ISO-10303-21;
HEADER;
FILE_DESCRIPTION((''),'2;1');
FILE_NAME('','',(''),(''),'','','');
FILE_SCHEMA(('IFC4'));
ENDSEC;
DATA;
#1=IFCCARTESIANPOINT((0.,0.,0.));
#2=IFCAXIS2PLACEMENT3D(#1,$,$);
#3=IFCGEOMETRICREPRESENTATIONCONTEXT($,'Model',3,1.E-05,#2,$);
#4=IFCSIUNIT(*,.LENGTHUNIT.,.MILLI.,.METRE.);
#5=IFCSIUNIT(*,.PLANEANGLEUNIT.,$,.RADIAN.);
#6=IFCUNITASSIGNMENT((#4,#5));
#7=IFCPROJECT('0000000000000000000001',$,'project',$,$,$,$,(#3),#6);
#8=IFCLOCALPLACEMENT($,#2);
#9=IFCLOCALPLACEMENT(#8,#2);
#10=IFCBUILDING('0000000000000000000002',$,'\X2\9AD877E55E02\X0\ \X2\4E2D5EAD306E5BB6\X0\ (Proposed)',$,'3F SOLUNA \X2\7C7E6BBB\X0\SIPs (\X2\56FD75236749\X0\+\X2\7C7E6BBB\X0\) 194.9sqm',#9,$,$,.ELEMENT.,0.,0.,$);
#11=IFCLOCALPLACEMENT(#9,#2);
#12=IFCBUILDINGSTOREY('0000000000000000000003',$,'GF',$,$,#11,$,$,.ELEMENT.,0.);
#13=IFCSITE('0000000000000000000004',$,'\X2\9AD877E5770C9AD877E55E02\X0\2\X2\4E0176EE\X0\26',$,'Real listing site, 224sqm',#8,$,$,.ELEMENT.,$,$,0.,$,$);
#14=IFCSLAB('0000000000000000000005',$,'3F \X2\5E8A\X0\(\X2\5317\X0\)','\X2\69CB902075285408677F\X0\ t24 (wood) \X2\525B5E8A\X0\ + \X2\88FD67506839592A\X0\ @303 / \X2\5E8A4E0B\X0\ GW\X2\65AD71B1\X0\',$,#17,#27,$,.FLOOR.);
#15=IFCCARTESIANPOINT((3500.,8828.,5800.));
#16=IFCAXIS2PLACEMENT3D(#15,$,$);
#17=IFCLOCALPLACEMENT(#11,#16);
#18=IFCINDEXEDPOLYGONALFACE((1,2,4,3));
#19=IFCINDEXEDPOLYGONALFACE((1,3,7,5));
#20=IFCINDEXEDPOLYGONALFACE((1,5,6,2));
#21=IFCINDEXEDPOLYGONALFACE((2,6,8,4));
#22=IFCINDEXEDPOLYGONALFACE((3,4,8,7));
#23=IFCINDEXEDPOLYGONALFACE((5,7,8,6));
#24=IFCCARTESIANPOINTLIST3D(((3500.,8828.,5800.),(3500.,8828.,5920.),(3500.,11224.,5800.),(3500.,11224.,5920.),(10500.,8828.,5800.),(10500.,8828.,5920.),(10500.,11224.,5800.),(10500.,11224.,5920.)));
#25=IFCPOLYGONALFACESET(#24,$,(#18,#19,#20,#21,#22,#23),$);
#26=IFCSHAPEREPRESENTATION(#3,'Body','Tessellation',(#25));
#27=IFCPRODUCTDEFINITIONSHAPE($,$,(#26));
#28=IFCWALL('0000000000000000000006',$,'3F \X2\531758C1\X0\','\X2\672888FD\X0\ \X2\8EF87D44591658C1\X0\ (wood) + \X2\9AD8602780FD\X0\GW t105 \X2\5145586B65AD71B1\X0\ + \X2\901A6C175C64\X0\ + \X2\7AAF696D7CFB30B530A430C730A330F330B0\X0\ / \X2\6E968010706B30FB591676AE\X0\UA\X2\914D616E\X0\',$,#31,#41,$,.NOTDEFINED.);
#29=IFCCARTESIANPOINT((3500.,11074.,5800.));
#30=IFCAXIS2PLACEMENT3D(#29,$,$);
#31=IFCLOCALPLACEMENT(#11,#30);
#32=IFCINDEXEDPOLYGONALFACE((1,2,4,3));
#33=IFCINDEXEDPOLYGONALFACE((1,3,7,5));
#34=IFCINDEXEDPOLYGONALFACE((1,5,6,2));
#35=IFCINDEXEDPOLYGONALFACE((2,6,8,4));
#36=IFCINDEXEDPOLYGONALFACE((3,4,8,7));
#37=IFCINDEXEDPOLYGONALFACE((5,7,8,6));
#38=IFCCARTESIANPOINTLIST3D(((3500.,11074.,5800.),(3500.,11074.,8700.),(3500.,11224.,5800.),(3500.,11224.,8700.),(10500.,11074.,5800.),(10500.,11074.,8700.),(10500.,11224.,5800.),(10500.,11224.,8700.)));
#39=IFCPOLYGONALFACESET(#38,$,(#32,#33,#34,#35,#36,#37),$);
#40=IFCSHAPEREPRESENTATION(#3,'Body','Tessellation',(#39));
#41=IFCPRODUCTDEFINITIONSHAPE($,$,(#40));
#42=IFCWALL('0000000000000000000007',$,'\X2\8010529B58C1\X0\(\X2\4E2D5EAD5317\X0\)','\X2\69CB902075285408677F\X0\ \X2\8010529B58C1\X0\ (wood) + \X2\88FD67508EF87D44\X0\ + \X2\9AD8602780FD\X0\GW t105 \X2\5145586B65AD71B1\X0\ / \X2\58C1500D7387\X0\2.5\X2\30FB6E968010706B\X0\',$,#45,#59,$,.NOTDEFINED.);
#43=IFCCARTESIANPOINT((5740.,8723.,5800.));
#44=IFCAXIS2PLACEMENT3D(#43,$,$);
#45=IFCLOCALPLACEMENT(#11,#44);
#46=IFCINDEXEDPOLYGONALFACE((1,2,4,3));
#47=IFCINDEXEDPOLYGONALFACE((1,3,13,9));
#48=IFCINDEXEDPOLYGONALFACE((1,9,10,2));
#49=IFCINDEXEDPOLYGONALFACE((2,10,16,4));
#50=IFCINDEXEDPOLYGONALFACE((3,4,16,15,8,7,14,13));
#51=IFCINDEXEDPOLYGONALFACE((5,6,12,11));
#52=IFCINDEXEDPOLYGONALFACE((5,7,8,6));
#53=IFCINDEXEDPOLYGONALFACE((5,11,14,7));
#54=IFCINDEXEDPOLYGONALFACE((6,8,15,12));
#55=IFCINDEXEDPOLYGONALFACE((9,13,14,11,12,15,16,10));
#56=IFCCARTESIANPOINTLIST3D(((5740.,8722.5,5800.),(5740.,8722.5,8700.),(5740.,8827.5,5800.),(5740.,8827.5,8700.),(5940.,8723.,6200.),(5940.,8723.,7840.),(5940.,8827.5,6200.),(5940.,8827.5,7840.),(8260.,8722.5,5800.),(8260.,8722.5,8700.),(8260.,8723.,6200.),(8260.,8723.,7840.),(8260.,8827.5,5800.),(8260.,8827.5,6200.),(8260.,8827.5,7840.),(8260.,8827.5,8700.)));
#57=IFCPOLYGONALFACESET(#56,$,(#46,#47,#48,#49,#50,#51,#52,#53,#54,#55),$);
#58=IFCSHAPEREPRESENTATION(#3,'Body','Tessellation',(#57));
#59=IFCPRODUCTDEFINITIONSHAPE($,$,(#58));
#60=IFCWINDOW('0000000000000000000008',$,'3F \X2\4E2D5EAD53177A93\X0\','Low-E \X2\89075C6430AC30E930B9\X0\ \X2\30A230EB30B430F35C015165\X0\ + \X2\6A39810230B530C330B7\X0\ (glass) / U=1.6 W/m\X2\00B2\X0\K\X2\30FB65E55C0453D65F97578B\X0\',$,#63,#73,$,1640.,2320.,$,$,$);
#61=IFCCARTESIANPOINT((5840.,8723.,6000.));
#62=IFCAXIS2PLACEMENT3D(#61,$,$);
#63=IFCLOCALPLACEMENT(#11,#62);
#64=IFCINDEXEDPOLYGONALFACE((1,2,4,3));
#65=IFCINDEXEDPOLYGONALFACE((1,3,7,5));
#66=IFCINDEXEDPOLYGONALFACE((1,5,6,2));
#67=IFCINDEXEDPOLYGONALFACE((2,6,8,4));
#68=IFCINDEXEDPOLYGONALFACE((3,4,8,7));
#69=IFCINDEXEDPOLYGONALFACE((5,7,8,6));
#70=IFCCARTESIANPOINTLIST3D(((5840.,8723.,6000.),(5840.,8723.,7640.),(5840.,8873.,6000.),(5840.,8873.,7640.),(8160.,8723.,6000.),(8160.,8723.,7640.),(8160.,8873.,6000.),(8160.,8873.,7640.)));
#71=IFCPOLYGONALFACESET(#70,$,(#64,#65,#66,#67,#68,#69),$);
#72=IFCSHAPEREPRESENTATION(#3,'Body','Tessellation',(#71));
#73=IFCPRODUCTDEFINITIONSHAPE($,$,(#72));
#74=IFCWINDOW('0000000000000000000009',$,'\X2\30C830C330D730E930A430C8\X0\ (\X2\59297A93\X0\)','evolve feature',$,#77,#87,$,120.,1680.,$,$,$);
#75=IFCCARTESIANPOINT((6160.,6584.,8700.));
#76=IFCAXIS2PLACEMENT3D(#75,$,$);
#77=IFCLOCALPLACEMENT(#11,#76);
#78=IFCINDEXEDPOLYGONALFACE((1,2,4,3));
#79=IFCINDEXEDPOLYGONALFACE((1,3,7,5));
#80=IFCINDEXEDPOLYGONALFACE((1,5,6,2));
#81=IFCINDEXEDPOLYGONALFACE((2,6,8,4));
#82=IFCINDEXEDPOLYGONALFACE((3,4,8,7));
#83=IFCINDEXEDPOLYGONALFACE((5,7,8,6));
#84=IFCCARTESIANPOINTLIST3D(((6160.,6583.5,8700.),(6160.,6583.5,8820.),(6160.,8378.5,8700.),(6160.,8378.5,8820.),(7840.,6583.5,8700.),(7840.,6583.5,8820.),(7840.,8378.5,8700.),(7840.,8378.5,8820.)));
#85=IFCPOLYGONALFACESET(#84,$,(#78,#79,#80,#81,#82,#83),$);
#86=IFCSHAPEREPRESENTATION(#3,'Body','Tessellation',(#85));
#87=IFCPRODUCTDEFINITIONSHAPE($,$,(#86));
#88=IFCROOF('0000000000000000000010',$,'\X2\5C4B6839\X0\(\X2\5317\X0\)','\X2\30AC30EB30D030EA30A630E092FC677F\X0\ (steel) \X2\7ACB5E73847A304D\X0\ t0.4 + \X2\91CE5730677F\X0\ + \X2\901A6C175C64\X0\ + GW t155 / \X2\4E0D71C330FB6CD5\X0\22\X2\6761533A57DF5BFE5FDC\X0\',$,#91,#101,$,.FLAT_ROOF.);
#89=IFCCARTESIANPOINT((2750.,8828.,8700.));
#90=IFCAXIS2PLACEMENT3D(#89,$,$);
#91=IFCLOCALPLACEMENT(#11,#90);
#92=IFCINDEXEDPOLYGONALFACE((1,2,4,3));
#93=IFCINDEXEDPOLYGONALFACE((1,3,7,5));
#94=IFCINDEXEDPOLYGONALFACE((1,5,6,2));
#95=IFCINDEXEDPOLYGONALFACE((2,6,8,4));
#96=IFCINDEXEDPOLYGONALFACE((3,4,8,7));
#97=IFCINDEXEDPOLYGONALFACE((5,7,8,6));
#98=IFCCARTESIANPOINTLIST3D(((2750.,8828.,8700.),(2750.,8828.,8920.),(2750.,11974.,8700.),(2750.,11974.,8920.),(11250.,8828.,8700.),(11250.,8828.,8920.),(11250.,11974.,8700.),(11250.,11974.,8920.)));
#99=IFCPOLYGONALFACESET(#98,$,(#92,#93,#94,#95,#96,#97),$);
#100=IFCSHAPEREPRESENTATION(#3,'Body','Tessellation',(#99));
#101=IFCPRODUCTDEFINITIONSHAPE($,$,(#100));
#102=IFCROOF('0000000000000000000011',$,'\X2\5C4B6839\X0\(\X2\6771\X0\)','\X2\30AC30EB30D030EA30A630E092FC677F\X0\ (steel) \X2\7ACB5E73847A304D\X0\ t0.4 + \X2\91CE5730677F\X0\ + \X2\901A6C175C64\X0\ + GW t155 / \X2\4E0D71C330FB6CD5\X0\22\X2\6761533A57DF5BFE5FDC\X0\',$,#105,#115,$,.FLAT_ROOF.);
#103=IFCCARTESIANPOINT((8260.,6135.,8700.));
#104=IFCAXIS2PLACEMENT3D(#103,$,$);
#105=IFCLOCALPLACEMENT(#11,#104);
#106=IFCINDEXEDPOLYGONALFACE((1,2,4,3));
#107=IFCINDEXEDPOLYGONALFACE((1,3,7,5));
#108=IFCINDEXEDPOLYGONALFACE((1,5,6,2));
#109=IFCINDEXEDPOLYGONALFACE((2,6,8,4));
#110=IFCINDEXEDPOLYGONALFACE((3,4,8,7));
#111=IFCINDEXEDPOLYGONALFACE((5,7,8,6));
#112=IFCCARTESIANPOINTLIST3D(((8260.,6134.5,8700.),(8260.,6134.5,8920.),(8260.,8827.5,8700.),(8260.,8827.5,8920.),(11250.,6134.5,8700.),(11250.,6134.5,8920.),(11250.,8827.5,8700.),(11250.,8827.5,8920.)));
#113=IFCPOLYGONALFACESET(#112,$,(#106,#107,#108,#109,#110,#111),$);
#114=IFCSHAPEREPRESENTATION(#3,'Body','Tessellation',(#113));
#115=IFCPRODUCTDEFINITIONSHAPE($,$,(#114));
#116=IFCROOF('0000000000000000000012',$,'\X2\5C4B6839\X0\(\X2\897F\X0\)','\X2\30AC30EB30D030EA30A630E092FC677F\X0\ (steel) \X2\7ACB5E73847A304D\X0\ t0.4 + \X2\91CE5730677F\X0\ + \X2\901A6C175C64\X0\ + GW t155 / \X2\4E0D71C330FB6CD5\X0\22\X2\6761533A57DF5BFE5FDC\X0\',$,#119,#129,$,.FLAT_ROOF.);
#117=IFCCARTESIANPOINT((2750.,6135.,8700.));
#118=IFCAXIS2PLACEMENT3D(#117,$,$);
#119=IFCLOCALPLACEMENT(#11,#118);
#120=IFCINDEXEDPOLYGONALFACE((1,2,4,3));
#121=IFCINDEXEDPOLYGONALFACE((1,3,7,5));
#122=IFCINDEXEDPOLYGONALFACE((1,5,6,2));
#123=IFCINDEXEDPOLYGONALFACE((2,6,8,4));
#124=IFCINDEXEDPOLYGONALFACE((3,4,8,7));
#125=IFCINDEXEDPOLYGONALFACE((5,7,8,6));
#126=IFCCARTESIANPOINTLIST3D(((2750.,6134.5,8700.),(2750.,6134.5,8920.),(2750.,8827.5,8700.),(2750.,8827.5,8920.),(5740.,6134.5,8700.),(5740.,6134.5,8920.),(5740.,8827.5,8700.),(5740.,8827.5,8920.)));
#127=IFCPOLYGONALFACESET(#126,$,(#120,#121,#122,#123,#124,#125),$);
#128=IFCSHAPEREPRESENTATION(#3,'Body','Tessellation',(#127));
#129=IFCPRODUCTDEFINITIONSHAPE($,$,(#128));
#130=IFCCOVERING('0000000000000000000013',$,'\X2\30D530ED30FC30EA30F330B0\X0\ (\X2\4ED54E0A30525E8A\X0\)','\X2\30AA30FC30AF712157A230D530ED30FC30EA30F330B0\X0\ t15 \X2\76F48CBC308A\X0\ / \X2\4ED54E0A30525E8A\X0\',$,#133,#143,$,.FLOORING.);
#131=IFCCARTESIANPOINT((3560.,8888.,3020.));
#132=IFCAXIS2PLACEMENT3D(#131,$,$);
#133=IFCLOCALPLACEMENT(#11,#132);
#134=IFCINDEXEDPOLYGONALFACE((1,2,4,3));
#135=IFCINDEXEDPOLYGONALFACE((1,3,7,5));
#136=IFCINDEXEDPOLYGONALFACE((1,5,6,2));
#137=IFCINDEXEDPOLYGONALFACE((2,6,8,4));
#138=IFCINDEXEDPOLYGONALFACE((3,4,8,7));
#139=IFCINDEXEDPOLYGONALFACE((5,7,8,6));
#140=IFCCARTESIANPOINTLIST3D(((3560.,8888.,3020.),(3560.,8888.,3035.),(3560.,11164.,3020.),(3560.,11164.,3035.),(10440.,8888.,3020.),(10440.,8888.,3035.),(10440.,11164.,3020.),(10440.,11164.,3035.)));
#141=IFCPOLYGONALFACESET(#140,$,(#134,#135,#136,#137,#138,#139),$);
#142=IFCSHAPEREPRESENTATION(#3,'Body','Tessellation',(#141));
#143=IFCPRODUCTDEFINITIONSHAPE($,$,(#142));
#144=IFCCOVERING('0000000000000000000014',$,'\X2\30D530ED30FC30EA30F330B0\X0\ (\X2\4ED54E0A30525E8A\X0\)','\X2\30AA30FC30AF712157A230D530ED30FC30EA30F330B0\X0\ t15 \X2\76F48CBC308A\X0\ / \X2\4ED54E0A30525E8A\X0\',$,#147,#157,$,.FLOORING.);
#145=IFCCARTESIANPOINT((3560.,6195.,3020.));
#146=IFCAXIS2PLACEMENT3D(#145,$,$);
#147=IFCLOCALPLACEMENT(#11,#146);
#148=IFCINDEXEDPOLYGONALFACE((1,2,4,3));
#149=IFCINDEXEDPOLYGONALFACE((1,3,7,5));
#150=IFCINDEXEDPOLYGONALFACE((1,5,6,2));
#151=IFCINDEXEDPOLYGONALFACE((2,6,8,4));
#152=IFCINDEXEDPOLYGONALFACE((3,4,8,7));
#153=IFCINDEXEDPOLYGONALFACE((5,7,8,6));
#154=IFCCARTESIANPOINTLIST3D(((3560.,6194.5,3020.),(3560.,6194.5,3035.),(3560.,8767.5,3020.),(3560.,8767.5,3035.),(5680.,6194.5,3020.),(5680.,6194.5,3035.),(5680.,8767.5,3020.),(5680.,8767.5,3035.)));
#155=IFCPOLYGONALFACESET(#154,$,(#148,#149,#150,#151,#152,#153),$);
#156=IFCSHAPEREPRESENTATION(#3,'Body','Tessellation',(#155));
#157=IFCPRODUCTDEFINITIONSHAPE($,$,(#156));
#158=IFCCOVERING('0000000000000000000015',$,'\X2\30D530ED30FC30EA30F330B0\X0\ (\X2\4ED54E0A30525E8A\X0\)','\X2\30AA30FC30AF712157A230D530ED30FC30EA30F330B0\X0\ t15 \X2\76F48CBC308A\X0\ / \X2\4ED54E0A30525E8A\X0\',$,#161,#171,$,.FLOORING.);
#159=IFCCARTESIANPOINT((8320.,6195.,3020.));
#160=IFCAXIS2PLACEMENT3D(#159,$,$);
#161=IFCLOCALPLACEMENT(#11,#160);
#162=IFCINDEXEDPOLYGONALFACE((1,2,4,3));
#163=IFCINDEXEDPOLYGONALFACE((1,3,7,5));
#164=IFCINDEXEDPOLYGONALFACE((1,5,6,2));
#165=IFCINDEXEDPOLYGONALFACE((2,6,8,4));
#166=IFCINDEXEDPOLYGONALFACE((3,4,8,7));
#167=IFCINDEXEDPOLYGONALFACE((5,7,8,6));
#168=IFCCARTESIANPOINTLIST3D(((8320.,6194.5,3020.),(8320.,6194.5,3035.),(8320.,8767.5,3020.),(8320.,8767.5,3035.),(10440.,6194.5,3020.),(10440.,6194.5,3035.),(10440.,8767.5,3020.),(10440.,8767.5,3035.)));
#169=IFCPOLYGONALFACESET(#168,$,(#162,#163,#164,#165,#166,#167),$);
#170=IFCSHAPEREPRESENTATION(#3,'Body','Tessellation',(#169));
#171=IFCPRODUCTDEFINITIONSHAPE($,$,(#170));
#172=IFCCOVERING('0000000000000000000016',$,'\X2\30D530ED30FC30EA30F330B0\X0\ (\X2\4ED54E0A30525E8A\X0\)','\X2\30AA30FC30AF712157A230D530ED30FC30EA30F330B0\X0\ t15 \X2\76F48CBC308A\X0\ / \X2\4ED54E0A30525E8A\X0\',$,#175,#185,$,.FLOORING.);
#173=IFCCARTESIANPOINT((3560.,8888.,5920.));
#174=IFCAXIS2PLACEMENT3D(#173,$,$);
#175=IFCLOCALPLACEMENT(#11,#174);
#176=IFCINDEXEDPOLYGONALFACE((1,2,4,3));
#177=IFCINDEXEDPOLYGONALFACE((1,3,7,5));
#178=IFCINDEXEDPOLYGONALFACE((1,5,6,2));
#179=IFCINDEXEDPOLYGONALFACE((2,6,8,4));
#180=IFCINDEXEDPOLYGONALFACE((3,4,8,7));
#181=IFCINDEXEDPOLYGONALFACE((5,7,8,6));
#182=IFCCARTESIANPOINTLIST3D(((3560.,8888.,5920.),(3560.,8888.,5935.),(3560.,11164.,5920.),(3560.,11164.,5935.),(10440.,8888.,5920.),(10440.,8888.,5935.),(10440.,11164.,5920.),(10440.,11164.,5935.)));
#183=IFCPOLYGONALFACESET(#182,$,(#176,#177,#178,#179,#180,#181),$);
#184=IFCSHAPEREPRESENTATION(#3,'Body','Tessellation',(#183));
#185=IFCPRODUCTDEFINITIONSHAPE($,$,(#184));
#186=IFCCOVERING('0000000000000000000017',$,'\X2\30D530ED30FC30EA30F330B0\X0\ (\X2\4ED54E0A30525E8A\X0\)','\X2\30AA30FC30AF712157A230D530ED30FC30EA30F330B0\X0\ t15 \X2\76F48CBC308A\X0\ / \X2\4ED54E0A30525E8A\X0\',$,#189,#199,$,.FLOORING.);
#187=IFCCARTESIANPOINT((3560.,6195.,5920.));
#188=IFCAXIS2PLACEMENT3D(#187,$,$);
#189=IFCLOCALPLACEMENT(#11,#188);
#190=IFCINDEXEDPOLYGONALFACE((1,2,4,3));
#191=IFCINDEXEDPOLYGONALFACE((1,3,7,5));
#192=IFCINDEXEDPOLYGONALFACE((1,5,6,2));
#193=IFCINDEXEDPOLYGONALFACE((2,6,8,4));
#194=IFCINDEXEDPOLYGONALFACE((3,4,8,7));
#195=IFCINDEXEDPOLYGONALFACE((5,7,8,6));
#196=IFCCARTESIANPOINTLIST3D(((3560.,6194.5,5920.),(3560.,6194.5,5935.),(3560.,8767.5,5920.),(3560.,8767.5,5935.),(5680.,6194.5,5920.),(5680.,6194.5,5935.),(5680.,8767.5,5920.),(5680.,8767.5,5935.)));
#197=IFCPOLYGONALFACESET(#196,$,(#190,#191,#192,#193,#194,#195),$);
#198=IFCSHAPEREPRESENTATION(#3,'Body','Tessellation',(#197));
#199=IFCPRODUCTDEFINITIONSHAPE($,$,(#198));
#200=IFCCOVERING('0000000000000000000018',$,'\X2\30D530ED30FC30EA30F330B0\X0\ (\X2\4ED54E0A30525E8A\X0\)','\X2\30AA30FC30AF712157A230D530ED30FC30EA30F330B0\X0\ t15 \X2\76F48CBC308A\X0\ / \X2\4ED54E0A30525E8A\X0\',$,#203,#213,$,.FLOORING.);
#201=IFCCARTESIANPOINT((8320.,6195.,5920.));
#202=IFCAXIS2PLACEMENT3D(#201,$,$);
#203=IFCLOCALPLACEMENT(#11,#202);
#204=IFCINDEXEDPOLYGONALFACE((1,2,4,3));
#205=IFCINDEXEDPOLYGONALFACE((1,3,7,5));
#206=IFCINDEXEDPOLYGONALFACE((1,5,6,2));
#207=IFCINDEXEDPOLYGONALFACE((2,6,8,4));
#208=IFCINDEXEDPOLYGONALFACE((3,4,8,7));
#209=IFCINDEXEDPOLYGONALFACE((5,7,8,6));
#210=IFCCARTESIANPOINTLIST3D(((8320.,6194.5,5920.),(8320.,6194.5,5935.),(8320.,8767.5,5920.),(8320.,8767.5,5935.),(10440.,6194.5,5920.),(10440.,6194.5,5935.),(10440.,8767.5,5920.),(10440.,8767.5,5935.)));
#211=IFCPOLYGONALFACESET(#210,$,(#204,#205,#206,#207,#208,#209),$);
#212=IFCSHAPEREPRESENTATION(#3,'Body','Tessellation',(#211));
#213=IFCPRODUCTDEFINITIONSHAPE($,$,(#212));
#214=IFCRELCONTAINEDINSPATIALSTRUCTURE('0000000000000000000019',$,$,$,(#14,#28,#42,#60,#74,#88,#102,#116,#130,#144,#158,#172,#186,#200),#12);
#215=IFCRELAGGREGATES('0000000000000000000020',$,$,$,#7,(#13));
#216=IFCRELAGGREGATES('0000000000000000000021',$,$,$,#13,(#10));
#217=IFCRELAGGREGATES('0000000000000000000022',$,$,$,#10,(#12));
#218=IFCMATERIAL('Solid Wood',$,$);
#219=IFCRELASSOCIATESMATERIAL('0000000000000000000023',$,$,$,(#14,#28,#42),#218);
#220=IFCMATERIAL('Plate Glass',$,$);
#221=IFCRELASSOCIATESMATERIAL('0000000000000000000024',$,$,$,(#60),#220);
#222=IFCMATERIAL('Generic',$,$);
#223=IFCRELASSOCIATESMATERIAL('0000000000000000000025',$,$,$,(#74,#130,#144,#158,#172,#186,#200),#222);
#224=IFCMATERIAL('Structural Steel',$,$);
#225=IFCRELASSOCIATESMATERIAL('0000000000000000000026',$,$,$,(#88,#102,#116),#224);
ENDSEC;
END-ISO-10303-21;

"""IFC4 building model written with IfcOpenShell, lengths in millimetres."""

from ifc_helpers import new_model, si_unit, frame, frame_2d, origin, place, context, project, spatial, rectangle, extrude, material, element, fill, save


model = new_model("IFC4")

# Units and contexts
model_context = context("Model", 3, precision=1e-05, world=origin())
ifc_project = project(units=[si_unit("LENGTHUNIT", "METRE", prefix="MILLI"), si_unit("PLANEANGLEUNIT", "RADIAN")], contexts=[model_context])

# Site, building, storey
site_placement = place(None, origin())
site = spatial("IfcSite", under=ifc_project, at=site_placement, Name="高知県高知市2丁目26", ObjectType="Real listing site, 224sqm", CompositionType="ELEMENT", RefElevation=0.0)
building_placement = place(site_placement, origin())
building = spatial("IfcBuilding", under=site, at=building_placement, Name="高知市 中庭の家 (Proposed)", ObjectType="3F SOLUNA 籾殻SIPs (国産杉+籾殻) 194.9sqm", CompositionType="ELEMENT", ElevationOfRefHeight=0.0, ElevationOfTerrain=0.0)
storey_placement = place(building_placement, origin())
storey = spatial("IfcBuildingStorey", under=building, at=storey_placement, Name="GF", CompositionType="ELEMENT", Elevation=0.0)

# Slab
ifc_material_1 = material(Name="Solid Wood")
slab_placement = place(storey_placement, frame((3500.0, 8828.0, 5800.0)))
element("IfcSlab", 1, at=slab_placement, inside=storey, material=ifc_material_1, Name="3F 床(北)", Description="構造用合板 t24 (wood) 剛床 + 製材根太 @303 / 床下 GW断熱", PredefinedType="FLOOR", context=model_context, shape_type="SweptSolid", body=[
    extrude(rectangle(XDim=7000.0, YDim=2396.0, at=frame_2d((3500.0, 1198.0))), frame((3500.0, 8828.0, 5800.0)), (0.0, 0.0, 1.0), 120.0),
])

# Wall
wall_1_placement = place(storey_placement, frame((3500.0, 11074.0, 5800.0)))
element("IfcWall", 2, at=wall_1_placement, inside=storey, material=ifc_material_1, Name="3F 北壁", Description="木製 軸組外壁 (wood) + 高性能GW t105 充填断熱 + 通気層 + 窯業系サイディング / 準耐火・外皮UA配慮", PredefinedType="NOTDEFINED", context=model_context, shape_type="SweptSolid", body=[
    extrude(rectangle(XDim=7000.0, YDim=150.0, at=frame_2d((3500.0, 75.0))), frame((3500.0, 11074.0, 5800.0)), (0.0, 0.0, 1.0), 2900.0),
])

# Wall, opening, window
wall_2_placement = place(storey_placement, frame((5740.0, 8723.0, 5800.0)))
wall_2 = element("IfcWall", 3, at=wall_2_placement, inside=storey, material=ifc_material_1, Name="耐力壁(中庭北)", Description="構造用合板 耐力壁 (wood) + 製材軸組 + 高性能GW t105 充填断熱 / 壁倍率2.5・準耐火", PredefinedType="NOTDEFINED", context=model_context, shape_type="SweptSolid", body=[
    extrude(rectangle(XDim=2520.0, YDim=105.0, at=frame_2d((1260.0, 52.0))), frame((5740.0, 8723.0, 5800.0)), (0.0, 0.0, 1.0), 2900.0),
])
opening_placement = place(storey_placement, frame((5840.0, 8723.0, 6000.0)))
opening = element("IfcOpeningElement", 4, at=opening_placement, cuts=wall_2, PredefinedType="NOTDEFINED", context=model_context, shape_type="SweptSolid", body=[
    extrude(rectangle(XDim=2320.0, YDim=150.0, at=frame_2d((1160.0, 75.0))), frame((5840.0, 8723.0, 6000.0)), (0.0, 0.0, 1.0), 1640.0),
])
ifc_material_2 = material(Name="Plate Glass")
window_1_placement = place(storey_placement, frame((5840.0, 8723.0, 6000.0)))
window_1 = element("IfcWindow", 5, at=window_1_placement, inside=storey, material=ifc_material_2, Name="3F 中庭北窓", Description="Low-E 複層ガラス アルゴン封入 + 樹脂サッシ (glass) / U=1.6 W/m²K・日射取得型", OverallHeight=1640.0, OverallWidth=2320.0, context=model_context, shape_type="SweptSolid", body=[
    extrude(rectangle(XDim=2320.0, YDim=150.0, at=frame_2d((1160.0, 75.0))), frame((5840.0, 8723.0, 6000.0)), (0.0, 0.0, 1.0), 1640.0),
])
fill(opening, window_1)

# Window
ifc_material_3 = material(Name="Generic")
window_2_placement = place(storey_placement, frame((6160.0, 6584.0, 8700.0)))
element("IfcWindow", 6, at=window_2_placement, inside=storey, material=ifc_material_3, Name="トップライト (天窓)", Description="evolve feature", OverallHeight=120.0, OverallWidth=1680.0, context=model_context, shape_type="SweptSolid", body=[
    extrude(rectangle(XDim=1680.0, YDim=1795.0, at=frame_2d((840.0, 897.0))), frame((6160.0, 6584.0, 8700.0)), (0.0, 0.0, 1.0), 120.0),
])

# Roofs
ifc_material_4 = material(Name="Structural Steel")
roof_1_placement = place(storey_placement, frame((2750.0, 8828.0, 8700.0)))
element("IfcRoof", 7, at=roof_1_placement, inside=storey, material=ifc_material_4, Name="屋根(北)", Description="ガルバリウム鋼板 (steel) 立平葺き t0.4 + 野地板 + 通気層 + GW t155 / 不燃・法22条区域対応", PredefinedType="FLAT_ROOF", context=model_context, shape_type="SweptSolid", body=[
    extrude(rectangle(XDim=8500.0, YDim=3146.0, at=frame_2d((4250.0, 1573.0))), frame((2750.0, 8828.0, 8700.0)), (0.0, 0.0, 1.0), 220.0),
])
roof_2_placement = place(storey_placement, frame((8260.0, 6135.0, 8700.0)))
element("IfcRoof", 8, at=roof_2_placement, inside=storey, material=ifc_material_4, Name="屋根(東)", Description="ガルバリウム鋼板 (steel) 立平葺き t0.4 + 野地板 + 通気層 + GW t155 / 不燃・法22条区域対応", PredefinedType="FLAT_ROOF", context=model_context, shape_type="SweptSolid", body=[
    extrude(rectangle(XDim=2990.0, YDim=2693.0, at=frame_2d((1495.0, 1346.0))), frame((8260.0, 6135.0, 8700.0)), (0.0, 0.0, 1.0), 220.0),
])
roof_3_placement = place(storey_placement, frame((2750.0, 6135.0, 8700.0)))
element("IfcRoof", 9, at=roof_3_placement, inside=storey, material=ifc_material_4, Name="屋根(西)", Description="ガルバリウム鋼板 (steel) 立平葺き t0.4 + 野地板 + 通気層 + GW t155 / 不燃・法22条区域対応", PredefinedType="FLAT_ROOF", context=model_context, shape_type="SweptSolid", body=[
    extrude(rectangle(XDim=2990.0, YDim=2693.0, at=frame_2d((1495.0, 1346.0))), frame((2750.0, 6135.0, 8700.0)), (0.0, 0.0, 1.0), 220.0),
])

# Coverings
covering_1_placement = place(storey_placement, frame((3560.0, 8888.0, 3020.0)))
element("IfcCovering", 10, at=covering_1_placement, inside=storey, material=ifc_material_3, Name="フローリング (仕上げ床)", Description="オーク無垢フローリング t15 直貼り / 仕上げ床", PredefinedType="FLOORING", context=model_context, shape_type="SweptSolid", body=[
    extrude(rectangle(XDim=6880.0, YDim=2276.0, at=frame_2d((3440.0, 1138.0))), frame((3560.0, 8888.0, 3020.0)), (0.0, 0.0, 1.0), 15.0),
])
covering_2_placement = place(storey_placement, frame((3560.0, 6195.0, 3020.0)))
element("IfcCovering", 11, at=covering_2_placement, inside=storey, material=ifc_material_3, Name="フローリング (仕上げ床)", Description="オーク無垢フローリング t15 直貼り / 仕上げ床", PredefinedType="FLOORING", context=model_context, shape_type="SweptSolid", body=[
    extrude(rectangle(XDim=2120.0, YDim=2573.0, at=frame_2d((1060.0, 1286.0))), frame((3560.0, 6195.0, 3020.0)), (0.0, 0.0, 1.0), 15.0),
])
covering_3_placement = place(storey_placement, frame((8320.0, 6195.0, 3020.0)))
element("IfcCovering", 12, at=covering_3_placement, inside=storey, material=ifc_material_3, Name="フローリング (仕上げ床)", Description="オーク無垢フローリング t15 直貼り / 仕上げ床", PredefinedType="FLOORING", context=model_context, shape_type="SweptSolid", body=[
    extrude(rectangle(XDim=2120.0, YDim=2573.0, at=frame_2d((1060.0, 1286.0))), frame((8320.0, 6195.0, 3020.0)), (0.0, 0.0, 1.0), 15.0),
])
covering_4_placement = place(storey_placement, frame((3560.0, 8888.0, 5920.0)))
element("IfcCovering", 13, at=covering_4_placement, inside=storey, material=ifc_material_3, Name="フローリング (仕上げ床)", Description="オーク無垢フローリング t15 直貼り / 仕上げ床", PredefinedType="FLOORING", context=model_context, shape_type="SweptSolid", body=[
    extrude(rectangle(XDim=6880.0, YDim=2276.0, at=frame_2d((3440.0, 1138.0))), frame((3560.0, 8888.0, 5920.0)), (0.0, 0.0, 1.0), 15.0),
])
covering_5_placement = place(storey_placement, frame((3560.0, 6195.0, 5920.0)))
element("IfcCovering", 14, at=covering_5_placement, inside=storey, material=ifc_material_3, Name="フローリング (仕上げ床)", Description="オーク無垢フローリング t15 直貼り / 仕上げ床", PredefinedType="FLOORING", context=model_context, shape_type="SweptSolid", body=[
    extrude(rectangle(XDim=2120.0, YDim=2573.0, at=frame_2d((1060.0, 1286.0))), frame((3560.0, 6195.0, 5920.0)), (0.0, 0.0, 1.0), 15.0),
])
covering_6_placement = place(storey_placement, frame((8320.0, 6195.0, 5920.0)))
element("IfcCovering", 15, at=covering_6_placement, inside=storey, material=ifc_material_3, Name="フローリング (仕上げ床)", Description="オーク無垢フローリング t15 直貼り / 仕上げ床", PredefinedType="FLOORING", context=model_context, shape_type="SweptSolid", body=[
    extrude(rectangle(XDim=2120.0, YDim=2573.0, at=frame_2d((1060.0, 1286.0))), frame((8320.0, 6195.0, 5920.0)), (0.0, 0.0, 1.0), 15.0),
])

save(model, "model.ifc")
